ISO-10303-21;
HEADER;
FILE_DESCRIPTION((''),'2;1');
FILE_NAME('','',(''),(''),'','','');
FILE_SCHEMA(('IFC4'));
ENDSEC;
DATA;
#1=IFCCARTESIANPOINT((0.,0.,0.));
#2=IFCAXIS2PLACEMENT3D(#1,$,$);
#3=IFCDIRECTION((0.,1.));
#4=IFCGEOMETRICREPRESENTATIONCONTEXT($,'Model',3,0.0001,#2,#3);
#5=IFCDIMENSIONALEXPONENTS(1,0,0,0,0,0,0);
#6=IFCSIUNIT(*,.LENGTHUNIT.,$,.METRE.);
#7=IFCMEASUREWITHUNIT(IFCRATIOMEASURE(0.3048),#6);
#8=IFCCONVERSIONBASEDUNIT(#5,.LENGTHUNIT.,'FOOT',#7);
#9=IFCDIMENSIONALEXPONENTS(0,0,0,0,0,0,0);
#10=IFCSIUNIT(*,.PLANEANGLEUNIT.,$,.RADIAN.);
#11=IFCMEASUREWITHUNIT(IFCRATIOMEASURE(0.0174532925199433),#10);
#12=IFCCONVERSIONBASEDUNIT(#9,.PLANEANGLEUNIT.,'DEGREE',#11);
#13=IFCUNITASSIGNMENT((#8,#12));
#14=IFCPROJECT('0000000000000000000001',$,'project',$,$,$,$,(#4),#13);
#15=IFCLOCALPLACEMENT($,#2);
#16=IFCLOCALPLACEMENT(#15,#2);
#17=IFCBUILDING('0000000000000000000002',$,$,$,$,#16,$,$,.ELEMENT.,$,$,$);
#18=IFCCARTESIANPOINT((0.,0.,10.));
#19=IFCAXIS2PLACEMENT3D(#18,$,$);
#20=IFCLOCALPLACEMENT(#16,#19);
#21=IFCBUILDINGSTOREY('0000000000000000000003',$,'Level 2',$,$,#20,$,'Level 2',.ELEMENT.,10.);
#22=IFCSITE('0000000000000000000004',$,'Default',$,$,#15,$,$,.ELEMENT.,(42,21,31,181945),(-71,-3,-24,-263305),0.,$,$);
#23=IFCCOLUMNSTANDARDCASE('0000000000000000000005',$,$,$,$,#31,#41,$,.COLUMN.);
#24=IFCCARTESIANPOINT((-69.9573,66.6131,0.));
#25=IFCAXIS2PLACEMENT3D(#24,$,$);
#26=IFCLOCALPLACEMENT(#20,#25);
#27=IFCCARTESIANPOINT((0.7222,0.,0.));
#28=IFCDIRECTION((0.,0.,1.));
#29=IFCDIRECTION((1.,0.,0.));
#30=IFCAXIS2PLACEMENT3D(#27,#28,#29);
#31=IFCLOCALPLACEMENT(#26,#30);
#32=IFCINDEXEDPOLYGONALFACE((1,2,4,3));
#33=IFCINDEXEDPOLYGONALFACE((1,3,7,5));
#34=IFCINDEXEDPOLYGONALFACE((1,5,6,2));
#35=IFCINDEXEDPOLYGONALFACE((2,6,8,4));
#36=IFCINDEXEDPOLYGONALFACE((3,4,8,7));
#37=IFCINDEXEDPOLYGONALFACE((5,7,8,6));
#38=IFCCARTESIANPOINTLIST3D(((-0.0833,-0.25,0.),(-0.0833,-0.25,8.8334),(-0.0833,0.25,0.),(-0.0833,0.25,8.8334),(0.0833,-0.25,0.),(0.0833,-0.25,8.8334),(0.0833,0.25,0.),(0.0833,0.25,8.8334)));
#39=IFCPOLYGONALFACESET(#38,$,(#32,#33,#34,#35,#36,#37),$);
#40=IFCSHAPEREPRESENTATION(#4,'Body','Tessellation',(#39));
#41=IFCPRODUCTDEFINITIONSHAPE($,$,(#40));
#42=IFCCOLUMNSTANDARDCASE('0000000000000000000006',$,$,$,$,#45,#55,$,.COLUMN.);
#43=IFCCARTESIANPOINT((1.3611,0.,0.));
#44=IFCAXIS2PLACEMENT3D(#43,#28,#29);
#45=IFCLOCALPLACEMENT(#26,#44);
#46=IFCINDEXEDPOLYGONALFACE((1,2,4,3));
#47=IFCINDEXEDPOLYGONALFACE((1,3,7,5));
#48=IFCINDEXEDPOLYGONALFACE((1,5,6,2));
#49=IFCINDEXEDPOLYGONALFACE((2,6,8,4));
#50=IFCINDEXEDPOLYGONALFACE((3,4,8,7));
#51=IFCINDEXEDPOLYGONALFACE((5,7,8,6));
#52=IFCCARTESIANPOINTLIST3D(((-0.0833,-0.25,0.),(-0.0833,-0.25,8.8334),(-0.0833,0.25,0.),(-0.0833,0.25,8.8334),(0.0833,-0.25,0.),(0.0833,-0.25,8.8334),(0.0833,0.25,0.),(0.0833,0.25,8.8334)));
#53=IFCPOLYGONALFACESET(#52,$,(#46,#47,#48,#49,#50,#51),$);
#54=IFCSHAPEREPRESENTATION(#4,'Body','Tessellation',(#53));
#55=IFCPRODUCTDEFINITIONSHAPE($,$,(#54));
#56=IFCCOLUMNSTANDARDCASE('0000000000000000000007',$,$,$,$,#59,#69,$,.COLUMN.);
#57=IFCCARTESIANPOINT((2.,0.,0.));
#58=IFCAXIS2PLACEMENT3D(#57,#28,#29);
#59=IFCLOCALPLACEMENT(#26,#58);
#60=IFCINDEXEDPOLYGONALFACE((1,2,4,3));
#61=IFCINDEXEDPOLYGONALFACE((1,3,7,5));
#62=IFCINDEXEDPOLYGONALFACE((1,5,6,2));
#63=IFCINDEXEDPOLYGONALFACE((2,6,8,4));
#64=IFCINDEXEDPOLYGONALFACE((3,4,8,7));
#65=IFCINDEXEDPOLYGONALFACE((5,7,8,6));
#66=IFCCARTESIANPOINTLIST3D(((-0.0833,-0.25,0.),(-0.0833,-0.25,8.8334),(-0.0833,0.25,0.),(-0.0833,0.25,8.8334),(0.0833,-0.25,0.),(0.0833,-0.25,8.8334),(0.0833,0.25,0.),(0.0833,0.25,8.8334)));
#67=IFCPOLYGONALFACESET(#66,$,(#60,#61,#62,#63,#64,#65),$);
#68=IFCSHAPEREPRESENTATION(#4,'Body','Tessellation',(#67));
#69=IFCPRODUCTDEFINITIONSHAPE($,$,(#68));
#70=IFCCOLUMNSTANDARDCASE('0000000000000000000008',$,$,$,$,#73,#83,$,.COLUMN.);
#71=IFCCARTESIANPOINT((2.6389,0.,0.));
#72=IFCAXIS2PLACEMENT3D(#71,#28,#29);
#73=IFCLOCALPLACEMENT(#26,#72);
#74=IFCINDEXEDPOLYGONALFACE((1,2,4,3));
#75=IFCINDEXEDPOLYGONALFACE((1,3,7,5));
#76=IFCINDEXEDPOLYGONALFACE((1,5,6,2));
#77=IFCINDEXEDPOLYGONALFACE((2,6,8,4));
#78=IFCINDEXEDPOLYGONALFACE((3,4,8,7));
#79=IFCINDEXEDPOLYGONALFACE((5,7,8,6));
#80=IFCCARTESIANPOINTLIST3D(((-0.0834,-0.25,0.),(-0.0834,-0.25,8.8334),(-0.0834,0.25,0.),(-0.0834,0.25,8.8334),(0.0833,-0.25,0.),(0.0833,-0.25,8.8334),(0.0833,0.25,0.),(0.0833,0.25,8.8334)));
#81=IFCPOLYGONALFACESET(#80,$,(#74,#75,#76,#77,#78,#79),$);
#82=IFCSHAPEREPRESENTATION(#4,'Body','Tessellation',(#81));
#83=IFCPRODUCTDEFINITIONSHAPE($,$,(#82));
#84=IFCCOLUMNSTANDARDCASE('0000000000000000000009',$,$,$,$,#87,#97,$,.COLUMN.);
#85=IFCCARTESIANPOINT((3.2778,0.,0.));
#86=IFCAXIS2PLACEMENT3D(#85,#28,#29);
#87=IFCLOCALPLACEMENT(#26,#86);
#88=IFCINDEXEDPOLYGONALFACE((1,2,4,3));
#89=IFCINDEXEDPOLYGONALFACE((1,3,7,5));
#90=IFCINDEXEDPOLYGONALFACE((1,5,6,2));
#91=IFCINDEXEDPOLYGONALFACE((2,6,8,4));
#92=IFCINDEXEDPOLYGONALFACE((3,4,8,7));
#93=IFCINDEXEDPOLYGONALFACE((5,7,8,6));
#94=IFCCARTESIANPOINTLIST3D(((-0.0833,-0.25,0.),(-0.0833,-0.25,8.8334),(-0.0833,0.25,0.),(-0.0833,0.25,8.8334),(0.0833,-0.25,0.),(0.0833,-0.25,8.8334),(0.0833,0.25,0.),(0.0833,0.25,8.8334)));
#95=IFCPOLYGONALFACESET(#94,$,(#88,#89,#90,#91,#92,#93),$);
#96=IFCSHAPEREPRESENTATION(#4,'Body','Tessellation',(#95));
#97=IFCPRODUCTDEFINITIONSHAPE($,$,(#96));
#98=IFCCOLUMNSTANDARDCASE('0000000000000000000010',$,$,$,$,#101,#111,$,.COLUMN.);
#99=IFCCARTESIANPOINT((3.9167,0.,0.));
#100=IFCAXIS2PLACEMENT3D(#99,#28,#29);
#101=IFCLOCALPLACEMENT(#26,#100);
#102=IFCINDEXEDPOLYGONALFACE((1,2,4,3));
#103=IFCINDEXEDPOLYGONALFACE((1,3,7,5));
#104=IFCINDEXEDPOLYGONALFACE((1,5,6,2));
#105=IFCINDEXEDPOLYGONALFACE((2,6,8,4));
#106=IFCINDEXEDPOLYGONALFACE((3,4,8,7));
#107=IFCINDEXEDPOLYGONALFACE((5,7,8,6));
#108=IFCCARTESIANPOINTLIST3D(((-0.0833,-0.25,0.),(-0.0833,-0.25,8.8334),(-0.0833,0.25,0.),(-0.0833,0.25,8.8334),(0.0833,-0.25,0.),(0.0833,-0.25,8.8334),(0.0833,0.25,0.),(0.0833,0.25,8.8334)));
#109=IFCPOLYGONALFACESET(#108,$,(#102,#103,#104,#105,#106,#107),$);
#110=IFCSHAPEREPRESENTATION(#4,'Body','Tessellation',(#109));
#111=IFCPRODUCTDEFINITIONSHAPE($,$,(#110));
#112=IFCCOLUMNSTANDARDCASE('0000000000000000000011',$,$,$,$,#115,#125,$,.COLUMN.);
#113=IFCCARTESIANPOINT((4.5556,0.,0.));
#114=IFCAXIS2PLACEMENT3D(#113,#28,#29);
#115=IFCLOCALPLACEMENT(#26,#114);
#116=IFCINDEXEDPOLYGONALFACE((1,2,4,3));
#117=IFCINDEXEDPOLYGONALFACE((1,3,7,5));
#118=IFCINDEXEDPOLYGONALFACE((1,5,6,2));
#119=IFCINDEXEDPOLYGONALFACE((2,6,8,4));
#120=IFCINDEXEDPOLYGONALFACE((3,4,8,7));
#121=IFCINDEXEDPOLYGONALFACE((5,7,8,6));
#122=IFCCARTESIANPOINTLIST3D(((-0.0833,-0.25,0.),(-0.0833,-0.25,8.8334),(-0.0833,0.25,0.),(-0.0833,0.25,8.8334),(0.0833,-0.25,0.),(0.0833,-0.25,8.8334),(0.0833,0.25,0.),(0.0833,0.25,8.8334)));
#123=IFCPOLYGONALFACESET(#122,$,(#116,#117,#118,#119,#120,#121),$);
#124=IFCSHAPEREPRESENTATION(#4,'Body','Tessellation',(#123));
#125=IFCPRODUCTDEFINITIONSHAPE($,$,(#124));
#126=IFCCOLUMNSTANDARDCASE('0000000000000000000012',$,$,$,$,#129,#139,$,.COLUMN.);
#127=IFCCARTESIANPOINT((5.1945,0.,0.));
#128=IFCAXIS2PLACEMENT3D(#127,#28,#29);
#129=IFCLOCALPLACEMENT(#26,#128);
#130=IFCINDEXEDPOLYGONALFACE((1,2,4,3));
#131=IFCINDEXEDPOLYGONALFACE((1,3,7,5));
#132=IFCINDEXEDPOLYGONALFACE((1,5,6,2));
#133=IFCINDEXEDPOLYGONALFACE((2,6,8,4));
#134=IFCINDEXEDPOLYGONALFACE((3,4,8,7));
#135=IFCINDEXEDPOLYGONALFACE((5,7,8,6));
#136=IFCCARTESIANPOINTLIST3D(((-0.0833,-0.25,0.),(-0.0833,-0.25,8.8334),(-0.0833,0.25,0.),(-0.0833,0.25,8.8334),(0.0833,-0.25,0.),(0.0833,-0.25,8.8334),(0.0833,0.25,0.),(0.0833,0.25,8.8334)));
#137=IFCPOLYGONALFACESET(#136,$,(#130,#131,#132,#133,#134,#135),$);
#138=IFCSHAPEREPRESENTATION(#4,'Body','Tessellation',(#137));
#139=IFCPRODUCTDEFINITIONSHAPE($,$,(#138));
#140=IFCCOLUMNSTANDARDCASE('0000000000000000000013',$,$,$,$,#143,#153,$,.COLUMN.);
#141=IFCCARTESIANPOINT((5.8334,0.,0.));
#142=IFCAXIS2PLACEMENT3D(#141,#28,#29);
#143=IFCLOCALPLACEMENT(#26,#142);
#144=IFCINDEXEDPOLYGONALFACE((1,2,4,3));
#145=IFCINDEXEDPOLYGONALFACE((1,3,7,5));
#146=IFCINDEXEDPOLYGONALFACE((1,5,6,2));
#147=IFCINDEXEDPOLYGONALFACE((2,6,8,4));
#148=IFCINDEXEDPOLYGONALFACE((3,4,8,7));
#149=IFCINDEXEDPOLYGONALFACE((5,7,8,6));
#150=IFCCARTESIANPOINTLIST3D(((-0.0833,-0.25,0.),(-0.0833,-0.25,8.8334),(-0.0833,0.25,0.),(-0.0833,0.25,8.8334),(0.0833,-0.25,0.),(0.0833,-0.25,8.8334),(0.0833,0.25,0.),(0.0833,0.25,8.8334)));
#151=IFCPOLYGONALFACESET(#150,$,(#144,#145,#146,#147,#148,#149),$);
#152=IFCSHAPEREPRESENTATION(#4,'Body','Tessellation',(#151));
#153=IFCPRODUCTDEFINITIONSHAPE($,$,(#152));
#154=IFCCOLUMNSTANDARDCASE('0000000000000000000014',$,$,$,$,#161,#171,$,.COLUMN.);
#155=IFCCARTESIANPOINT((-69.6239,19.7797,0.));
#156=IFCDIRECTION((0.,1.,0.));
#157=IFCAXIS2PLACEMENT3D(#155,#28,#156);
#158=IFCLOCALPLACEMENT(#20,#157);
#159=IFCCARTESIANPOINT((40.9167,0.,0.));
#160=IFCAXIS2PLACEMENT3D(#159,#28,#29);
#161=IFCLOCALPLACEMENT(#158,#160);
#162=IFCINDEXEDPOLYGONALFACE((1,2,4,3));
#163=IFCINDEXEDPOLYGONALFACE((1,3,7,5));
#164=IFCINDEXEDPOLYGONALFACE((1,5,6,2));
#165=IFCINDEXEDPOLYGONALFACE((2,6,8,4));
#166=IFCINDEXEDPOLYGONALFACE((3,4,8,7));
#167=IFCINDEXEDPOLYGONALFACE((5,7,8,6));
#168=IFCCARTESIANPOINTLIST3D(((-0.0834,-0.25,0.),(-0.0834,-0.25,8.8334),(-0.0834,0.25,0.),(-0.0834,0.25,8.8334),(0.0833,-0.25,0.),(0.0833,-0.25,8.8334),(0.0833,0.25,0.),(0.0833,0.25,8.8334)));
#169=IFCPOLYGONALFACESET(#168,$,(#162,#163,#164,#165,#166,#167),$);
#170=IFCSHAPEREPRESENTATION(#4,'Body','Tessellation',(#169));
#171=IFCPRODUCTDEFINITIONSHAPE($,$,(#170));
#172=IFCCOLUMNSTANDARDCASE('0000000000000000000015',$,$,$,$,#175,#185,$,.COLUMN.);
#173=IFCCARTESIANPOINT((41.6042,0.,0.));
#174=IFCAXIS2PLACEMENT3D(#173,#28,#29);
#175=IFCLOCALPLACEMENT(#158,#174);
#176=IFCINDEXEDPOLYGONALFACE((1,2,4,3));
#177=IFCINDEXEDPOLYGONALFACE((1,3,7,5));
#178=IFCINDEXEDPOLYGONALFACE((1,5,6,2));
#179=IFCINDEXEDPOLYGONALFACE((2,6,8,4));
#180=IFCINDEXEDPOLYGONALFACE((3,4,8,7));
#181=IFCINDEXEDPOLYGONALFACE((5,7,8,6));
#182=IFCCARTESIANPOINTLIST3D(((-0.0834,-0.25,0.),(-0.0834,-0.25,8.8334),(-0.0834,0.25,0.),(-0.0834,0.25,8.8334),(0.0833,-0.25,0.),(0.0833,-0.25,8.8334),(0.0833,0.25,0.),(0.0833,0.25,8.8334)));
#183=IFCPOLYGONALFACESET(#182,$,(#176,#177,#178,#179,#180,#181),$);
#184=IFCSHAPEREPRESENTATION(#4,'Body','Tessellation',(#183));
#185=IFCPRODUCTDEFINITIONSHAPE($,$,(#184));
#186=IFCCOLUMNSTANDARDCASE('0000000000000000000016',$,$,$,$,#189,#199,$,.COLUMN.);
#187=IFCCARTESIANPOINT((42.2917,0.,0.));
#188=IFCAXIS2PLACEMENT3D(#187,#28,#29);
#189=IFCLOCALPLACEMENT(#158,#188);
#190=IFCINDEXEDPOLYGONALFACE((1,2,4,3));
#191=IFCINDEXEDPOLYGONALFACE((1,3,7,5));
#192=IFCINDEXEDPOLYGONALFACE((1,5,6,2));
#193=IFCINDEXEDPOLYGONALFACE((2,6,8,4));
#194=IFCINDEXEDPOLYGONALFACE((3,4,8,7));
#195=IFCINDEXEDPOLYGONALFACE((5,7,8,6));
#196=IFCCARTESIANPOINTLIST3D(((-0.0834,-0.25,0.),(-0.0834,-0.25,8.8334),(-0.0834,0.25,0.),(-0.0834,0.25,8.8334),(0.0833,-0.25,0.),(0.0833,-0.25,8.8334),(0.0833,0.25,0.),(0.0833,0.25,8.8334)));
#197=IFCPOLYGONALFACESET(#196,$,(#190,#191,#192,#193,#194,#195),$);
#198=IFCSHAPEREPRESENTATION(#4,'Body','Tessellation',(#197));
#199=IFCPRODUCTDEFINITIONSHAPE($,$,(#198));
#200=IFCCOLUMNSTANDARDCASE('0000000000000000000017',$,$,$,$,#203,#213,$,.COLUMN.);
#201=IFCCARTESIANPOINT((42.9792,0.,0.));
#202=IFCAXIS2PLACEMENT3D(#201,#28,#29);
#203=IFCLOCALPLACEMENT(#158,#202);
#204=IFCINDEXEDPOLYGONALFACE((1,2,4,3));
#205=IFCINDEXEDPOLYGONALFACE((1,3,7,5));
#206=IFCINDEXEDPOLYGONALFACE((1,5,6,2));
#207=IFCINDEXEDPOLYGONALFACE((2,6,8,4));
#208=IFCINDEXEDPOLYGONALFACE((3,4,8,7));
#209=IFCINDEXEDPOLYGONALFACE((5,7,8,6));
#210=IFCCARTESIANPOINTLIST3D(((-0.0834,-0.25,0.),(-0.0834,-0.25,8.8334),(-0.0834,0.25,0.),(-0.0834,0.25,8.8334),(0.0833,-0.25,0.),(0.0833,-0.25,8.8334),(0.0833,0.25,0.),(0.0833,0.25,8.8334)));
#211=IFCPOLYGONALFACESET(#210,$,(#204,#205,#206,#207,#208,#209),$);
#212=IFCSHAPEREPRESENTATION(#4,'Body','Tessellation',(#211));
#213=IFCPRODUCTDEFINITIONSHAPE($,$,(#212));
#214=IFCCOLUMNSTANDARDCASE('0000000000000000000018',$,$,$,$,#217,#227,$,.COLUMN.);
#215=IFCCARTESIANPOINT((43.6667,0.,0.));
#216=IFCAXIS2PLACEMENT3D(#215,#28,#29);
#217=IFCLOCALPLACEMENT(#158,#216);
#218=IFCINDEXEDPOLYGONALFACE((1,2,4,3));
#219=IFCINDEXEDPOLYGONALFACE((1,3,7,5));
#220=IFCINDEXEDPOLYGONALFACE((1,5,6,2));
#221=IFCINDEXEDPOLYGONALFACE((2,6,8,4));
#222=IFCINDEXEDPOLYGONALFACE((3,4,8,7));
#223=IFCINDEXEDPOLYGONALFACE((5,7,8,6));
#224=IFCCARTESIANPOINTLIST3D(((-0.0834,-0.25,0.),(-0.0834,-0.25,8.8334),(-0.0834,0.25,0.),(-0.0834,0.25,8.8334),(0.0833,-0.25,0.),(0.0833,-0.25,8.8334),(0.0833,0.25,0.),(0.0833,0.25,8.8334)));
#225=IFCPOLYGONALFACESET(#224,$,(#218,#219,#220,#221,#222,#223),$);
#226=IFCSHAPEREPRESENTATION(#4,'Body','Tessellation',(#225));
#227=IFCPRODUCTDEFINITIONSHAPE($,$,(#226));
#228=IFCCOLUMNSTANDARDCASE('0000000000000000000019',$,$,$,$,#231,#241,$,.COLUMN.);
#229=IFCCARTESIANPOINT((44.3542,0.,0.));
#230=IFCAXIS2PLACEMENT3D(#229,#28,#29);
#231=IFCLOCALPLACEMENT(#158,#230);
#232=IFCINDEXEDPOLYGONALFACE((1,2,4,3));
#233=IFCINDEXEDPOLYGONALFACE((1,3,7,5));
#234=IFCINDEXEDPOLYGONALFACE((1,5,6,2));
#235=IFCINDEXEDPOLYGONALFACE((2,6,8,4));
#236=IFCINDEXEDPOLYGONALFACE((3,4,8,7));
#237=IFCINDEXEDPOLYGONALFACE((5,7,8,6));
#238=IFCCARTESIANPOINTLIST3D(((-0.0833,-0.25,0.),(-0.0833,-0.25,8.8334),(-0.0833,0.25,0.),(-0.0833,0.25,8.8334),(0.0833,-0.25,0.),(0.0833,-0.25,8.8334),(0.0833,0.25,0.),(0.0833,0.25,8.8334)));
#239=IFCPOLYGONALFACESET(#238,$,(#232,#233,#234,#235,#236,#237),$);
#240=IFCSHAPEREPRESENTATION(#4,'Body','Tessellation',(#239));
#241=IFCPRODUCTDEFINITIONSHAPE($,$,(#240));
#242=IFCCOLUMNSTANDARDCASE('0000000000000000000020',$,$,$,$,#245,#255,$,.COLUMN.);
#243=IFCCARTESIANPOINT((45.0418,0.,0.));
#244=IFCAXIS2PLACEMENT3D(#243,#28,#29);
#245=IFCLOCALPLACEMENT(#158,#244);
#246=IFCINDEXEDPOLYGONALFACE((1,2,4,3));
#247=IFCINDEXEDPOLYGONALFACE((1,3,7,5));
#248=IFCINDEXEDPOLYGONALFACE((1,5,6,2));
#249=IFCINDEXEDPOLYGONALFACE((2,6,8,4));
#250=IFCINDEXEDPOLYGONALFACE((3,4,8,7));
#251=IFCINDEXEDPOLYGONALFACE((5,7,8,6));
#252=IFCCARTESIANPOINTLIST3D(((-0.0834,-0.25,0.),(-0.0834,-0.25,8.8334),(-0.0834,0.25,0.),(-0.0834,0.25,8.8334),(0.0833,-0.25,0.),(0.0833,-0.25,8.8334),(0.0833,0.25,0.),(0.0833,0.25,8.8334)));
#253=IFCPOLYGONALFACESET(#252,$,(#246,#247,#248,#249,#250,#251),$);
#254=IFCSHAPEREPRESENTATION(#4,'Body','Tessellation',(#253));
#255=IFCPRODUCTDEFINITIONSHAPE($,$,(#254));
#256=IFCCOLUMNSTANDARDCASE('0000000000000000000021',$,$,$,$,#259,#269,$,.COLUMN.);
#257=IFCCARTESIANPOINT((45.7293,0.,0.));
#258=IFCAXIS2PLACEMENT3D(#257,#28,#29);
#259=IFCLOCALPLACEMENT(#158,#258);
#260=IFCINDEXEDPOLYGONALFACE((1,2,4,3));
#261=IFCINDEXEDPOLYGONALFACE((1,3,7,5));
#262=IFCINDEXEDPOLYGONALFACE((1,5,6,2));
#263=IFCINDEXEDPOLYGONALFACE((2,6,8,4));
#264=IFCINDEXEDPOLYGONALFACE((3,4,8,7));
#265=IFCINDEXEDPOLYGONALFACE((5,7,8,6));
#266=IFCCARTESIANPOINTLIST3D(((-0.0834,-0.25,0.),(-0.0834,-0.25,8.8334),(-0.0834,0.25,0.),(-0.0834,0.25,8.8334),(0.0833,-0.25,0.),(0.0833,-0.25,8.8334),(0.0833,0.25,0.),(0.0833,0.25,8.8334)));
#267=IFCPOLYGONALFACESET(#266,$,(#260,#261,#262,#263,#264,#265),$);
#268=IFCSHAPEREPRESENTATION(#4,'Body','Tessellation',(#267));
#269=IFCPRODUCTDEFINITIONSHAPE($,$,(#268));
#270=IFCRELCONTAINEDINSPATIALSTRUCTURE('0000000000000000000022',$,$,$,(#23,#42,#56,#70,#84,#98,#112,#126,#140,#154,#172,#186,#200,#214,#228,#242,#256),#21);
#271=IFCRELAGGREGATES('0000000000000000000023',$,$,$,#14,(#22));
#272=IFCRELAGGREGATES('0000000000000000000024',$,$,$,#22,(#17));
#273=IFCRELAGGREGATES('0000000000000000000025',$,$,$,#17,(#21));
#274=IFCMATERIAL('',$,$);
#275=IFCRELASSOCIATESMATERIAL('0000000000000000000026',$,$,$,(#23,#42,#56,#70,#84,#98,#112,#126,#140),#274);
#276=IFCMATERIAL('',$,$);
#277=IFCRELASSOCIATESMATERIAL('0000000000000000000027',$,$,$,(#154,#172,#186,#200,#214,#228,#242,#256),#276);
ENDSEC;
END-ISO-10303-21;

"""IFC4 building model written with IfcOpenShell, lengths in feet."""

from ifc_helpers import new_model, entity, si_unit, converted_unit, direction, frame, origin, place, context, project, spatial, rectangle, extrude, material, element, save


model = new_model("IFC4")

# Units and contexts
model_context = context("Model", 3, precision=0.0001, world=origin(), true_north=direction((0.0, 1.0)))
ifc_project = project(units=[converted_unit("LENGTHUNIT", "FOOT", entity("IfcRatioMeasure", 0.3048), si_unit("LENGTHUNIT", "METRE"), dimensions=[1, 0, 0, 0, 0, 0, 0]), converted_unit("PLANEANGLEUNIT", "DEGREE", entity("IfcRatioMeasure", 0.0174532925199433), si_unit("PLANEANGLEUNIT", "RADIAN"), dimensions=[0, 0, 0, 0, 0, 0, 0])], contexts=[model_context])

# Site, building, storey
site_placement = place(None, origin())
site = spatial("IfcSite", under=ifc_project, at=site_placement, Name="Default", CompositionType="ELEMENT", RefLatitude=(42, 21, 31, 181945), RefLongitude=(-71, -3, -24, -263305), RefElevation=0.0)
building_placement = place(site_placement, origin())
building = spatial("IfcBuilding", under=site, at=building_placement, CompositionType="ELEMENT")
storey_placement = place(building_placement, frame((0.0, 0.0, 10.0)))
storey = spatial("IfcBuildingStorey", under=building, at=storey_placement, Name="Level 2", LongName="Level 2", CompositionType="ELEMENT", Elevation=10.0)

# Columns
ifc_material_1 = material(Name="")
placement_1 = place(storey_placement, frame((-69.9573, 66.6131, 0.0)))
for number, where, z_axis, x_axis in (
    (1, (0.7222, 0.0, 0.0), (0.0, 0.0, 1.0), (1.0, 0.0, 0.0)),
    (2, (1.3611, 0.0, 0.0), (0.0, 0.0, 1.0), (1.0, 0.0, 0.0)),
    (3, (2.0, 0.0, 0.0), (0.0, 0.0, 1.0), (1.0, 0.0, 0.0)),
    (4, (2.6389, 0.0, 0.0), (0.0, 0.0, 1.0), (1.0, 0.0, 0.0)),
    (5, (3.2778, 0.0, 0.0), (0.0, 0.0, 1.0), (1.0, 0.0, 0.0)),
    (6, (3.9167, 0.0, 0.0), (0.0, 0.0, 1.0), (1.0, 0.0, 0.0)),
    (7, (4.5556, 0.0, 0.0), (0.0, 0.0, 1.0), (1.0, 0.0, 0.0)),
    (8, (5.1945, 0.0, 0.0), (0.0, 0.0, 1.0), (1.0, 0.0, 0.0)),
    (9, (5.8334, 0.0, 0.0), (0.0, 0.0, 1.0), (1.0, 0.0, 0.0)),
):
    element("IfcColumnStandardCase", number, at=place(placement_1, frame(where, z_axis=z_axis, x_axis=x_axis)), inside=storey, material=ifc_material_1, PredefinedType="COLUMN", context=model_context, shape_type="SweptSolid", body=[
        extrude(rectangle(XDim=0.1667, YDim=0.5), origin(), (0.0, 0.0, 1.0), 8.8334),
    ])
ifc_material_2 = material(Name="")
placement_2 = place(storey_placement, frame((-69.6239, 19.7797, 0.0), z_axis=(0.0, 0.0, 1.0), x_axis=(0.0, 1.0, 0.0)))
for number, where, z_axis, x_axis in (
    (10, (40.9167, 0.0, 0.0), (0.0, 0.0, 1.0), (1.0, 0.0, 0.0)),
    (11, (41.6042, 0.0, 0.0), (0.0, 0.0, 1.0), (1.0, 0.0, 0.0)),
    (12, (42.2917, 0.0, 0.0), (0.0, 0.0, 1.0), (1.0, 0.0, 0.0)),
    (13, (42.9792, 0.0, 0.0), (0.0, 0.0, 1.0), (1.0, 0.0, 0.0)),
    (14, (43.6667, 0.0, 0.0), (0.0, 0.0, 1.0), (1.0, 0.0, 0.0)),
    (15, (44.3542, 0.0, 0.0), (0.0, 0.0, 1.0), (1.0, 0.0, 0.0)),
    (16, (45.0418, 0.0, 0.0), (0.0, 0.0, 1.0), (1.0, 0.0, 0.0)),
    (17, (45.7293, 0.0, 0.0), (0.0, 0.0, 1.0), (1.0, 0.0, 0.0)),
):
    element("IfcColumnStandardCase", number, at=place(placement_2, frame(where, z_axis=z_axis, x_axis=x_axis)), inside=storey, material=ifc_material_2, PredefinedType="COLUMN", context=model_context, shape_type="SweptSolid", body=[
        extrude(rectangle(XDim=0.1667, YDim=0.5), origin(), (0.0, 0.0, 1.0), 8.8334),
    ])

save(model, "model.ifc")
